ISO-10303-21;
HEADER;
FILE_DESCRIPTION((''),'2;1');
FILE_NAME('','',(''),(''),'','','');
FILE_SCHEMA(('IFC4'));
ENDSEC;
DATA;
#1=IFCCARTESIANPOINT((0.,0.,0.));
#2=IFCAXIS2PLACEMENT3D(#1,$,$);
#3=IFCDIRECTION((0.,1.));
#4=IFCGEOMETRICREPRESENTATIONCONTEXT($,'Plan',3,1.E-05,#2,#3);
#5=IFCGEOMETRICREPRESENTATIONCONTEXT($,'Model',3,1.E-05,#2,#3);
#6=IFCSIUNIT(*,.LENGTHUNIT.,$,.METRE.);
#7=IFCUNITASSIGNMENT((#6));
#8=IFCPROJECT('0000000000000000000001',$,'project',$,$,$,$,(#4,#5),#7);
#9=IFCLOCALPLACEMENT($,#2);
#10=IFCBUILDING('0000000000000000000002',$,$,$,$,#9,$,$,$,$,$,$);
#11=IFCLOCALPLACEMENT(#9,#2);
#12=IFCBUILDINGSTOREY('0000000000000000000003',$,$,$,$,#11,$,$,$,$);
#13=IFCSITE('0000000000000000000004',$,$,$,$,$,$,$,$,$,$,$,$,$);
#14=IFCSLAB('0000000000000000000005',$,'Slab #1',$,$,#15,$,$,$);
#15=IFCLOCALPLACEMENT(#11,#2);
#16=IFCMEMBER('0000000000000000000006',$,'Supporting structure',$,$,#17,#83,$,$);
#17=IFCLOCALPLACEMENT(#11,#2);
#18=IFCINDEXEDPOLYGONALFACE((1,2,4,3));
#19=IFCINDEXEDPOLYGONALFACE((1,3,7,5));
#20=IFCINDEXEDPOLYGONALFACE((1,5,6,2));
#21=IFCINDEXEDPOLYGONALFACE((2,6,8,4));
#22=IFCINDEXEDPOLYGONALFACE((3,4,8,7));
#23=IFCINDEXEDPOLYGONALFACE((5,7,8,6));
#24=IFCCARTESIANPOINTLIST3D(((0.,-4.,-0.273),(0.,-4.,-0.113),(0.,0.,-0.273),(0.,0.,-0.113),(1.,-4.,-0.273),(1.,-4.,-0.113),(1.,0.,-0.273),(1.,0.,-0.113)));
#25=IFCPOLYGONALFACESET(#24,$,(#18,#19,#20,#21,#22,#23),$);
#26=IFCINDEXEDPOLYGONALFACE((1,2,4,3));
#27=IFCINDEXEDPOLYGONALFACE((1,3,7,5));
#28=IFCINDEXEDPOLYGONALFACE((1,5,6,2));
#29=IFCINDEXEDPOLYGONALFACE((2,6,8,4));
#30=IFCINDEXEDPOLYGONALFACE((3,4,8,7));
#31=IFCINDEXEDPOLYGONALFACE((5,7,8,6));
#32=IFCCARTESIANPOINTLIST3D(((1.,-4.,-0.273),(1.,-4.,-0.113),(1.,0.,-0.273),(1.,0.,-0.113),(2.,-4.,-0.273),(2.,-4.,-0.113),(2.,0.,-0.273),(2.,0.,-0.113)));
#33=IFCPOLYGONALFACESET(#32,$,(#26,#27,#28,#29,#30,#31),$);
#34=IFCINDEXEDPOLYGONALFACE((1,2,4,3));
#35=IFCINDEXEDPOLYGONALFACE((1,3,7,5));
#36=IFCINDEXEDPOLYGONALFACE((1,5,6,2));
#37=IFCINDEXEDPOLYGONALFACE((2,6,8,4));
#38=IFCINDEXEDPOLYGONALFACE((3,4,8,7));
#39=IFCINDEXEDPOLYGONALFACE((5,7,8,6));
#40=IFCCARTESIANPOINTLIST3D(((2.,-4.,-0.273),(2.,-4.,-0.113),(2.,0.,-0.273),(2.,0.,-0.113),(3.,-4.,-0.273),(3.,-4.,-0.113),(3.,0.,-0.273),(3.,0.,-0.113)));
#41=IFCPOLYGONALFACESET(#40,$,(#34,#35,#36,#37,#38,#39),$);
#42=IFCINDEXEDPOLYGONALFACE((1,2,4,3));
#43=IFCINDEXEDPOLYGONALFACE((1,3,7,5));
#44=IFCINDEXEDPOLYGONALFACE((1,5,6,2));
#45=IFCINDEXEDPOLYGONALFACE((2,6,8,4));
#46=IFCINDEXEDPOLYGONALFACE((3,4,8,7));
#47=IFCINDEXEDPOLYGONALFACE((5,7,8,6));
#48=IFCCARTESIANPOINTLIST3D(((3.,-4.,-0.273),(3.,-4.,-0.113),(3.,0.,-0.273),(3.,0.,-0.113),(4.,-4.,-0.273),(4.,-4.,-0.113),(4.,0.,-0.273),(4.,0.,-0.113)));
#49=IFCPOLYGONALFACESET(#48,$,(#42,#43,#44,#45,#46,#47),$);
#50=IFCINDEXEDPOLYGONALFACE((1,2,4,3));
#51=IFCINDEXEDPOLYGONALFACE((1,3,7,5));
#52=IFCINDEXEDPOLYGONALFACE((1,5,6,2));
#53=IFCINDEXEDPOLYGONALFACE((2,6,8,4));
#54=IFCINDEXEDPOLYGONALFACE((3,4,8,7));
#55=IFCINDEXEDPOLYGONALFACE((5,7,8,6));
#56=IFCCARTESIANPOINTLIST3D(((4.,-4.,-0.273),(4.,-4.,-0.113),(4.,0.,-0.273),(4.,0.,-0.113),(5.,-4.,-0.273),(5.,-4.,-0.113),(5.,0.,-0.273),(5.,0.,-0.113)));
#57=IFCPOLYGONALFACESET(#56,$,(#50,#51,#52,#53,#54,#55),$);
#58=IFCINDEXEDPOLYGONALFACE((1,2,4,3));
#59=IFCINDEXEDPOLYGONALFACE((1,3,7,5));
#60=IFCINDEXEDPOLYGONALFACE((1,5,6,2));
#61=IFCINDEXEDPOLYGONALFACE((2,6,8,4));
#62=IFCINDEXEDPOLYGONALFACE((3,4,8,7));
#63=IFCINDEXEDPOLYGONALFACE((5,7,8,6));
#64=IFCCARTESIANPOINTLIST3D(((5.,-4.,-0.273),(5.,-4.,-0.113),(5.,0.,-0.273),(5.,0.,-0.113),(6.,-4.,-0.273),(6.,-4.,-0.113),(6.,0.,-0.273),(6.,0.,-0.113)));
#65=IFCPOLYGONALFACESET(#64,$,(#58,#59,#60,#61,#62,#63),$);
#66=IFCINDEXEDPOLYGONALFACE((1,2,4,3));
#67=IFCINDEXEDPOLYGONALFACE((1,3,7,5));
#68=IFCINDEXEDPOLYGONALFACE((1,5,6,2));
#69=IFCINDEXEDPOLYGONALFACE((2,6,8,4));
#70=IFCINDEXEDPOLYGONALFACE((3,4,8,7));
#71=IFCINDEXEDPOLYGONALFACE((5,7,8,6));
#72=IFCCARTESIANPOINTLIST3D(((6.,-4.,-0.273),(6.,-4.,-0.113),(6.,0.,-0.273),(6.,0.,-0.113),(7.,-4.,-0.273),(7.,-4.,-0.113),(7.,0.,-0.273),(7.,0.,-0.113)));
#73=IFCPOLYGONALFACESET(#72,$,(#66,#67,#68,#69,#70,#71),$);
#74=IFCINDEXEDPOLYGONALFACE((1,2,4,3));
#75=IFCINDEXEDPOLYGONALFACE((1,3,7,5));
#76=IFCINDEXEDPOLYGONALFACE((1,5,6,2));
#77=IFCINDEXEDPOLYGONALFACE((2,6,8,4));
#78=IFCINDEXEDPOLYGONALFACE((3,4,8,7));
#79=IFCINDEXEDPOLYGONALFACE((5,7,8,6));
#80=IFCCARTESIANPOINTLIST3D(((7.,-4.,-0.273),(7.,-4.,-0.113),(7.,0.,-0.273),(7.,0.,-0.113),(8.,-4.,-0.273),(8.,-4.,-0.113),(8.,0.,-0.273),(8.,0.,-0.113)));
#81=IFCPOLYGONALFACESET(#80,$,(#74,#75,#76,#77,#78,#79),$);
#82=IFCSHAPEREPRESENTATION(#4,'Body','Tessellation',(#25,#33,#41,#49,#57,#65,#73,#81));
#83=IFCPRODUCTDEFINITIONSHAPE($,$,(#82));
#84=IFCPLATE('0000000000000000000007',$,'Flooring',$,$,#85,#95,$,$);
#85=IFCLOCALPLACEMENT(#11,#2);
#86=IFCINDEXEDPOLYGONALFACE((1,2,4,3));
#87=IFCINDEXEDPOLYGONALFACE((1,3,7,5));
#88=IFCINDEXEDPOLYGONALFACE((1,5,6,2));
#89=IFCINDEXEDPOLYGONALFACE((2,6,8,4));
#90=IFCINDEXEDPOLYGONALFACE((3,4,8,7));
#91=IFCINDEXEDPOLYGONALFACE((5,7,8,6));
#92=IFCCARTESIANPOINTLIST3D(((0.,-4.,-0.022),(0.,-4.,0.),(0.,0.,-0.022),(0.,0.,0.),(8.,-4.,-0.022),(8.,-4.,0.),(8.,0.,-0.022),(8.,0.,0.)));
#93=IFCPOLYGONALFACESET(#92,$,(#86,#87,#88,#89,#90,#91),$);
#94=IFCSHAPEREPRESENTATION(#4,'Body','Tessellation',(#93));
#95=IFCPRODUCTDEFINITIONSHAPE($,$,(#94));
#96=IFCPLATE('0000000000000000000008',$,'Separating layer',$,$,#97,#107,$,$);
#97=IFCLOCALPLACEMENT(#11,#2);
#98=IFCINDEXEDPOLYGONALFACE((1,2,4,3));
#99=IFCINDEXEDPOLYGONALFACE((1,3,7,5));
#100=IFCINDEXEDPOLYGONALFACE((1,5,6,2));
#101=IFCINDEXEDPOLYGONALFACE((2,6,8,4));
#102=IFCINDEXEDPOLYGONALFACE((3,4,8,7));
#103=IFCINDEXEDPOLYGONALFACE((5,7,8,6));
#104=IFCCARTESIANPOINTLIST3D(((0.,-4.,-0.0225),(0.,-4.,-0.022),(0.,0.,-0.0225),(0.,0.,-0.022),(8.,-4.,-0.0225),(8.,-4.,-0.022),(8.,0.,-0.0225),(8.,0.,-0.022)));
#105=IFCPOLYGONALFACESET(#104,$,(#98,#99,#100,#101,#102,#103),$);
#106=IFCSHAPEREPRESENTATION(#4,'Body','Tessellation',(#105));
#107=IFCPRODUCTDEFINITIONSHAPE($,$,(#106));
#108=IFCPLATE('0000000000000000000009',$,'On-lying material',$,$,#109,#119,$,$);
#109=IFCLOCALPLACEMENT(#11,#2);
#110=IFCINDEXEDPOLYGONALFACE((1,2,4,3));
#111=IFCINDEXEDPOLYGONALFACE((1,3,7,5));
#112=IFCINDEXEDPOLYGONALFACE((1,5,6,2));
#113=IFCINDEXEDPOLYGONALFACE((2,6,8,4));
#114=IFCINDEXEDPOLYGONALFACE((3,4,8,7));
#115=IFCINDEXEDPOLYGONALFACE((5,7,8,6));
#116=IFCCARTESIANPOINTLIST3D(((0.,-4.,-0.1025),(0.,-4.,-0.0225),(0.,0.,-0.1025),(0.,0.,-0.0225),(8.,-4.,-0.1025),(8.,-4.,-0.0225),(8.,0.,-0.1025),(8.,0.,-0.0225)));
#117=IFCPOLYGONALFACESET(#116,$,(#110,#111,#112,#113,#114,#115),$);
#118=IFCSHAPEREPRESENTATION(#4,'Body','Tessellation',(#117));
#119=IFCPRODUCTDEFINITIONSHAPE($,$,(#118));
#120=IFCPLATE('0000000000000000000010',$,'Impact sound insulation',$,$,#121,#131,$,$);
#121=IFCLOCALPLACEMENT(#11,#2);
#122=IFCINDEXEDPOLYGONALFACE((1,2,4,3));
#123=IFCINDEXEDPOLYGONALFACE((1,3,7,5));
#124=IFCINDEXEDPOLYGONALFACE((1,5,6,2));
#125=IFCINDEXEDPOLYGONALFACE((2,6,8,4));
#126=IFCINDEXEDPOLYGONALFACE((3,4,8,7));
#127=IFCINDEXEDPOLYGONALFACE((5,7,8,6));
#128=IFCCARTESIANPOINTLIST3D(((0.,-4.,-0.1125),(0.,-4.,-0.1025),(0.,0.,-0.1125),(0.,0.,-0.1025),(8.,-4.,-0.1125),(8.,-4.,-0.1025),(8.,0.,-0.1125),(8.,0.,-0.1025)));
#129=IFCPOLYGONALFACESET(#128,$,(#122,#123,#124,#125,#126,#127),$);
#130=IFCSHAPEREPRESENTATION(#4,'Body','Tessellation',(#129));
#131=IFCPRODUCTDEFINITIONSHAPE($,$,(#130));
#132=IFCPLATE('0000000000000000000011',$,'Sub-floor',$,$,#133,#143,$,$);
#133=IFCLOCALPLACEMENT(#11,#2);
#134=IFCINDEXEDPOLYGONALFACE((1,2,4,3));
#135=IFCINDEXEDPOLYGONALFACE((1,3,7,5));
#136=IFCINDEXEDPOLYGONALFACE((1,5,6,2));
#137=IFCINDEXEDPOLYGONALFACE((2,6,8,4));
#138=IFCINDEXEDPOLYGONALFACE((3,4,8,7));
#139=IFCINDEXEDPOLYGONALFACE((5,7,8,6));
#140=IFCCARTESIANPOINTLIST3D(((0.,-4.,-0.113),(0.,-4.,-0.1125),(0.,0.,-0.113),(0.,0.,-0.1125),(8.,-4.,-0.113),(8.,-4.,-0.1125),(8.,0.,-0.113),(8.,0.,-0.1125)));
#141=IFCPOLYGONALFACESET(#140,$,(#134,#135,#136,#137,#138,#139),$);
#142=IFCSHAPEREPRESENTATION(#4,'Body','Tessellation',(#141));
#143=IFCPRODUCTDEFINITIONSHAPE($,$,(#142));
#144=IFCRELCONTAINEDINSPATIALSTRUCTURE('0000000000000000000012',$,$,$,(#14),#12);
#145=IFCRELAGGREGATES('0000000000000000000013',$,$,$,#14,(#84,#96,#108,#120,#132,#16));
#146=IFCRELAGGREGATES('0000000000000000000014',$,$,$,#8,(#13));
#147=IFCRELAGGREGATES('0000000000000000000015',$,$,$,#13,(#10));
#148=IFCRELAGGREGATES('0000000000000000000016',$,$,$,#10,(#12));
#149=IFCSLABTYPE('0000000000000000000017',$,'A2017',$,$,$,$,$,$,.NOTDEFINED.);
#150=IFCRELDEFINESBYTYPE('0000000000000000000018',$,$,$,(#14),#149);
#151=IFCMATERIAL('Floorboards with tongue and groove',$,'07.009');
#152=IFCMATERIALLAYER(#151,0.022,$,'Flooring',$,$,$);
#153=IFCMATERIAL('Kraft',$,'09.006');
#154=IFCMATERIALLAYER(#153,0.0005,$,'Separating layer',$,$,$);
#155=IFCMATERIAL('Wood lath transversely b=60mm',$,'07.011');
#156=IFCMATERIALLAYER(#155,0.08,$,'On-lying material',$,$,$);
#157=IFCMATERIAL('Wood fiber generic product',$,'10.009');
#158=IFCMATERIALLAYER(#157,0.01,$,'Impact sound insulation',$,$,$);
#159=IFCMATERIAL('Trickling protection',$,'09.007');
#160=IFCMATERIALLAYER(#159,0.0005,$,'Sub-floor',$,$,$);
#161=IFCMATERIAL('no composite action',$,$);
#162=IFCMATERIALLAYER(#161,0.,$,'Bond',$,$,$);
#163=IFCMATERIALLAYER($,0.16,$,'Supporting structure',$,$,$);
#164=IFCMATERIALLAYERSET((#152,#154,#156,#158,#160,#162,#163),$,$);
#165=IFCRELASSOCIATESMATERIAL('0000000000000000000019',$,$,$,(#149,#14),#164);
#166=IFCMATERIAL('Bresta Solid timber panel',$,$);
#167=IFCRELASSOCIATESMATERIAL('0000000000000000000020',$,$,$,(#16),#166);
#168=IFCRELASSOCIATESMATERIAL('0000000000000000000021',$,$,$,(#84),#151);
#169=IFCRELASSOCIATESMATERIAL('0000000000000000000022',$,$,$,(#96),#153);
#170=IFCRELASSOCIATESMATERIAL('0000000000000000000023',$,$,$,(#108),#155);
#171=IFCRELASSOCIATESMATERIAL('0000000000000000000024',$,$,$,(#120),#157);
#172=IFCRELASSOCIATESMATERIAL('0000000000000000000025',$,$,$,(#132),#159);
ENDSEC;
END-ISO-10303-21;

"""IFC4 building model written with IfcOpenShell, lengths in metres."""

from ifc_helpers import new_model, si_unit, direction, frame, frame_2d, origin, origin_with_axes, place, context, project, spatial, rectangle, extrude, material, layer, layer_set, type_object, element, aggregate, save


model = new_model("IFC4")

# Units and contexts
plan_context = context("Plan", 3, precision=1e-05, world=origin(), true_north=direction((0.0, 1.0)))
model_context = context("Model", 3, precision=1e-05, world=origin(), true_north=direction((0.0, 1.0)))
ifc_project = project(units=[si_unit("LENGTHUNIT", "METRE")], contexts=[plan_context, model_context])

# Site, building, storey
site = spatial("IfcSite", under=ifc_project)
building_placement = place(None, origin())
building = spatial("IfcBuilding", under=site, at=building_placement)
storey_placement = place(building_placement, origin())
storey = spatial("IfcBuildingStorey", under=building, at=storey_placement)

# Slab, member, plates
ifc_material_1 = material(Name="Floorboards with tongue and groove", Category="07.009")
ifc_layer_1 = layer(ifc_material_1, 0.022, Name="Flooring")
ifc_material_2 = material(Name="Kraft", Category="09.006")
ifc_layer_2 = layer(ifc_material_2, 0.0005, Name="Separating layer")
ifc_material_3 = material(Name="Wood lath transversely b=60mm", Category="07.011")
ifc_layer_3 = layer(ifc_material_3, 0.08, Name="On-lying material")
ifc_material_4 = material(Name="Wood fiber generic product", Category="10.009")
ifc_layer_4 = layer(ifc_material_4, 0.01, Name="Impact sound insulation")
ifc_material_5 = material(Name="Trickling protection", Category="09.007")
ifc_layer_5 = layer(ifc_material_5, 0.0005, Name="Sub-floor")
ifc_material_6 = material(Name="no composite action")
ifc_layer_6 = layer(ifc_material_6, 0.0, Name="Bond")
ifc_layer_7 = layer(None, 0.16, Name="Supporting structure")
ifc_layer_set = layer_set([ifc_layer_1, ifc_layer_2, ifc_layer_3, ifc_layer_4, ifc_layer_5, ifc_layer_6, ifc_layer_7])
slab_type = type_object("IfcSlabType", Name="A2017", PredefinedType="NOTDEFINED", material=ifc_layer_set)
slab_placement = place(None, frame((0.0, 0.0, 0.0), z_axis=(0.0, 0.0, -1.0), x_axis=(1.0, 0.0, 0.0)))
slab = element("IfcSlab", 1, at=slab_placement, inside=storey, type_object=slab_type, material=ifc_layer_set, Name="Slab #1")
ifc_material_7 = material(Name="Bresta Solid timber panel")
member_placement = place(slab_placement, origin())
member = element("IfcMember", 2, at=member_placement, material=ifc_material_7, Name="Supporting structure", context=plan_context, shape_type="SweptSolid", body=[
    extrude(rectangle(XDim=1.0, YDim=0.16, at=frame_2d((0.5, 0.08), x_axis=(1.0, 0.0))), frame((0.0, 4.0, 0.113), z_axis=(0.0, -1.0, 0.0), x_axis=(1.0, 0.0, 0.0)), (0.0, 0.0, 1.0), 4.0),
    extrude(rectangle(XDim=1.0, YDim=0.16, at=frame_2d((0.5, 0.08), x_axis=(1.0, 0.0))), frame((1.0, 4.0, 0.113), z_axis=(0.0, -1.0, 0.0), x_axis=(1.0, 0.0, 0.0)), (0.0, 0.0, 1.0), 4.0),
    extrude(rectangle(XDim=1.0, YDim=0.16, at=frame_2d((0.5, 0.08), x_axis=(1.0, 0.0))), frame((2.0, 4.0, 0.113), z_axis=(0.0, -1.0, 0.0), x_axis=(1.0, 0.0, 0.0)), (0.0, 0.0, 1.0), 4.0),
    extrude(rectangle(XDim=1.0, YDim=0.16, at=frame_2d((0.5, 0.08), x_axis=(1.0, 0.0))), frame((3.0, 4.0, 0.113), z_axis=(0.0, -1.0, 0.0), x_axis=(1.0, 0.0, 0.0)), (0.0, 0.0, 1.0), 4.0),
    extrude(rectangle(XDim=1.0, YDim=0.16, at=frame_2d((0.5, 0.08), x_axis=(1.0, 0.0))), frame((4.0, 4.0, 0.113), z_axis=(0.0, -1.0, 0.0), x_axis=(1.0, 0.0, 0.0)), (0.0, 0.0, 1.0), 4.0),
    extrude(rectangle(XDim=1.0, YDim=0.16, at=frame_2d((0.5, 0.08), x_axis=(1.0, 0.0))), frame((5.0, 4.0, 0.113), z_axis=(0.0, -1.0, 0.0), x_axis=(1.0, 0.0, 0.0)), (0.0, 0.0, 1.0), 4.0),
    extrude(rectangle(XDim=1.0, YDim=0.16, at=frame_2d((0.5, 0.08), x_axis=(1.0, 0.0))), frame((6.0, 4.0, 0.113), z_axis=(0.0, -1.0, 0.0), x_axis=(1.0, 0.0, 0.0)), (0.0, 0.0, 1.0), 4.0),
    extrude(rectangle(XDim=1.0, YDim=0.16, at=frame_2d((0.5, 0.08), x_axis=(1.0, 0.0))), frame((7.0, 4.0, 0.113), z_axis=(0.0, -1.0, 0.0), x_axis=(1.0, 0.0, 0.0)), (0.0, 0.0, 1.0), 4.0),
])
plate_1_placement = place(slab_placement, origin())
plate_1 = element("IfcPlate", 3, at=plate_1_placement, material=ifc_material_1, Name="Flooring", context=plan_context, shape_type="SweptSolid", body=[
    extrude(rectangle(XDim=8.0, YDim=4.0, at=frame_2d((4.0, 2.0), x_axis=(1.0, 0.0))), origin_with_axes(), (0.0, 0.0, 1.0), 0.022),
])
plate_2_placement = place(slab_placement, origin())
plate_2 = element("IfcPlate", 4, at=plate_2_placement, material=ifc_material_2, Name="Separating layer", context=plan_context, shape_type="SweptSolid", body=[
    extrude(rectangle(XDim=8.0, YDim=4.0, at=frame_2d((4.0, 2.0), x_axis=(1.0, 0.0))), frame((0.0, 0.0, 0.022), z_axis=(0.0, 0.0, 1.0), x_axis=(1.0, 0.0, 0.0)), (0.0, 0.0, 1.0), 0.0005),
])
plate_3_placement = place(slab_placement, origin())
plate_3 = element("IfcPlate", 5, at=plate_3_placement, material=ifc_material_3, Name="On-lying material", context=plan_context, shape_type="SweptSolid", body=[
    extrude(rectangle(XDim=8.0, YDim=4.0, at=frame_2d((4.0, 2.0), x_axis=(1.0, 0.0))), frame((0.0, 0.0, 0.0225), z_axis=(0.0, 0.0, 1.0), x_axis=(1.0, 0.0, 0.0)), (0.0, 0.0, 1.0), 0.08),
])
plate_4_placement = place(slab_placement, origin())
plate_4 = element("IfcPlate", 6, at=plate_4_placement, material=ifc_material_4, Name="Impact sound insulation", context=plan_context, shape_type="SweptSolid", body=[
    extrude(rectangle(XDim=8.0, YDim=4.0, at=frame_2d((4.0, 2.0), x_axis=(1.0, 0.0))), frame((0.0, 0.0, 0.1025), z_axis=(0.0, 0.0, 1.0), x_axis=(1.0, 0.0, 0.0)), (0.0, 0.0, 1.0), 0.01),
])
plate_5_placement = place(slab_placement, origin())
plate_5 = element("IfcPlate", 7, at=plate_5_placement, material=ifc_material_5, Name="Sub-floor", context=plan_context, shape_type="SweptSolid", body=[
    extrude(rectangle(XDim=8.0, YDim=4.0, at=frame_2d((4.0, 2.0), x_axis=(1.0, 0.0))), frame((0.0, 0.0, 0.1125), z_axis=(0.0, 0.0, 1.0), x_axis=(1.0, 0.0, 0.0)), (0.0, 0.0, 1.0), 0.0005),
])
aggregate(slab, [plate_1, plate_2, plate_3, plate_4, plate_5, member])

save(model, "model.ifc")
